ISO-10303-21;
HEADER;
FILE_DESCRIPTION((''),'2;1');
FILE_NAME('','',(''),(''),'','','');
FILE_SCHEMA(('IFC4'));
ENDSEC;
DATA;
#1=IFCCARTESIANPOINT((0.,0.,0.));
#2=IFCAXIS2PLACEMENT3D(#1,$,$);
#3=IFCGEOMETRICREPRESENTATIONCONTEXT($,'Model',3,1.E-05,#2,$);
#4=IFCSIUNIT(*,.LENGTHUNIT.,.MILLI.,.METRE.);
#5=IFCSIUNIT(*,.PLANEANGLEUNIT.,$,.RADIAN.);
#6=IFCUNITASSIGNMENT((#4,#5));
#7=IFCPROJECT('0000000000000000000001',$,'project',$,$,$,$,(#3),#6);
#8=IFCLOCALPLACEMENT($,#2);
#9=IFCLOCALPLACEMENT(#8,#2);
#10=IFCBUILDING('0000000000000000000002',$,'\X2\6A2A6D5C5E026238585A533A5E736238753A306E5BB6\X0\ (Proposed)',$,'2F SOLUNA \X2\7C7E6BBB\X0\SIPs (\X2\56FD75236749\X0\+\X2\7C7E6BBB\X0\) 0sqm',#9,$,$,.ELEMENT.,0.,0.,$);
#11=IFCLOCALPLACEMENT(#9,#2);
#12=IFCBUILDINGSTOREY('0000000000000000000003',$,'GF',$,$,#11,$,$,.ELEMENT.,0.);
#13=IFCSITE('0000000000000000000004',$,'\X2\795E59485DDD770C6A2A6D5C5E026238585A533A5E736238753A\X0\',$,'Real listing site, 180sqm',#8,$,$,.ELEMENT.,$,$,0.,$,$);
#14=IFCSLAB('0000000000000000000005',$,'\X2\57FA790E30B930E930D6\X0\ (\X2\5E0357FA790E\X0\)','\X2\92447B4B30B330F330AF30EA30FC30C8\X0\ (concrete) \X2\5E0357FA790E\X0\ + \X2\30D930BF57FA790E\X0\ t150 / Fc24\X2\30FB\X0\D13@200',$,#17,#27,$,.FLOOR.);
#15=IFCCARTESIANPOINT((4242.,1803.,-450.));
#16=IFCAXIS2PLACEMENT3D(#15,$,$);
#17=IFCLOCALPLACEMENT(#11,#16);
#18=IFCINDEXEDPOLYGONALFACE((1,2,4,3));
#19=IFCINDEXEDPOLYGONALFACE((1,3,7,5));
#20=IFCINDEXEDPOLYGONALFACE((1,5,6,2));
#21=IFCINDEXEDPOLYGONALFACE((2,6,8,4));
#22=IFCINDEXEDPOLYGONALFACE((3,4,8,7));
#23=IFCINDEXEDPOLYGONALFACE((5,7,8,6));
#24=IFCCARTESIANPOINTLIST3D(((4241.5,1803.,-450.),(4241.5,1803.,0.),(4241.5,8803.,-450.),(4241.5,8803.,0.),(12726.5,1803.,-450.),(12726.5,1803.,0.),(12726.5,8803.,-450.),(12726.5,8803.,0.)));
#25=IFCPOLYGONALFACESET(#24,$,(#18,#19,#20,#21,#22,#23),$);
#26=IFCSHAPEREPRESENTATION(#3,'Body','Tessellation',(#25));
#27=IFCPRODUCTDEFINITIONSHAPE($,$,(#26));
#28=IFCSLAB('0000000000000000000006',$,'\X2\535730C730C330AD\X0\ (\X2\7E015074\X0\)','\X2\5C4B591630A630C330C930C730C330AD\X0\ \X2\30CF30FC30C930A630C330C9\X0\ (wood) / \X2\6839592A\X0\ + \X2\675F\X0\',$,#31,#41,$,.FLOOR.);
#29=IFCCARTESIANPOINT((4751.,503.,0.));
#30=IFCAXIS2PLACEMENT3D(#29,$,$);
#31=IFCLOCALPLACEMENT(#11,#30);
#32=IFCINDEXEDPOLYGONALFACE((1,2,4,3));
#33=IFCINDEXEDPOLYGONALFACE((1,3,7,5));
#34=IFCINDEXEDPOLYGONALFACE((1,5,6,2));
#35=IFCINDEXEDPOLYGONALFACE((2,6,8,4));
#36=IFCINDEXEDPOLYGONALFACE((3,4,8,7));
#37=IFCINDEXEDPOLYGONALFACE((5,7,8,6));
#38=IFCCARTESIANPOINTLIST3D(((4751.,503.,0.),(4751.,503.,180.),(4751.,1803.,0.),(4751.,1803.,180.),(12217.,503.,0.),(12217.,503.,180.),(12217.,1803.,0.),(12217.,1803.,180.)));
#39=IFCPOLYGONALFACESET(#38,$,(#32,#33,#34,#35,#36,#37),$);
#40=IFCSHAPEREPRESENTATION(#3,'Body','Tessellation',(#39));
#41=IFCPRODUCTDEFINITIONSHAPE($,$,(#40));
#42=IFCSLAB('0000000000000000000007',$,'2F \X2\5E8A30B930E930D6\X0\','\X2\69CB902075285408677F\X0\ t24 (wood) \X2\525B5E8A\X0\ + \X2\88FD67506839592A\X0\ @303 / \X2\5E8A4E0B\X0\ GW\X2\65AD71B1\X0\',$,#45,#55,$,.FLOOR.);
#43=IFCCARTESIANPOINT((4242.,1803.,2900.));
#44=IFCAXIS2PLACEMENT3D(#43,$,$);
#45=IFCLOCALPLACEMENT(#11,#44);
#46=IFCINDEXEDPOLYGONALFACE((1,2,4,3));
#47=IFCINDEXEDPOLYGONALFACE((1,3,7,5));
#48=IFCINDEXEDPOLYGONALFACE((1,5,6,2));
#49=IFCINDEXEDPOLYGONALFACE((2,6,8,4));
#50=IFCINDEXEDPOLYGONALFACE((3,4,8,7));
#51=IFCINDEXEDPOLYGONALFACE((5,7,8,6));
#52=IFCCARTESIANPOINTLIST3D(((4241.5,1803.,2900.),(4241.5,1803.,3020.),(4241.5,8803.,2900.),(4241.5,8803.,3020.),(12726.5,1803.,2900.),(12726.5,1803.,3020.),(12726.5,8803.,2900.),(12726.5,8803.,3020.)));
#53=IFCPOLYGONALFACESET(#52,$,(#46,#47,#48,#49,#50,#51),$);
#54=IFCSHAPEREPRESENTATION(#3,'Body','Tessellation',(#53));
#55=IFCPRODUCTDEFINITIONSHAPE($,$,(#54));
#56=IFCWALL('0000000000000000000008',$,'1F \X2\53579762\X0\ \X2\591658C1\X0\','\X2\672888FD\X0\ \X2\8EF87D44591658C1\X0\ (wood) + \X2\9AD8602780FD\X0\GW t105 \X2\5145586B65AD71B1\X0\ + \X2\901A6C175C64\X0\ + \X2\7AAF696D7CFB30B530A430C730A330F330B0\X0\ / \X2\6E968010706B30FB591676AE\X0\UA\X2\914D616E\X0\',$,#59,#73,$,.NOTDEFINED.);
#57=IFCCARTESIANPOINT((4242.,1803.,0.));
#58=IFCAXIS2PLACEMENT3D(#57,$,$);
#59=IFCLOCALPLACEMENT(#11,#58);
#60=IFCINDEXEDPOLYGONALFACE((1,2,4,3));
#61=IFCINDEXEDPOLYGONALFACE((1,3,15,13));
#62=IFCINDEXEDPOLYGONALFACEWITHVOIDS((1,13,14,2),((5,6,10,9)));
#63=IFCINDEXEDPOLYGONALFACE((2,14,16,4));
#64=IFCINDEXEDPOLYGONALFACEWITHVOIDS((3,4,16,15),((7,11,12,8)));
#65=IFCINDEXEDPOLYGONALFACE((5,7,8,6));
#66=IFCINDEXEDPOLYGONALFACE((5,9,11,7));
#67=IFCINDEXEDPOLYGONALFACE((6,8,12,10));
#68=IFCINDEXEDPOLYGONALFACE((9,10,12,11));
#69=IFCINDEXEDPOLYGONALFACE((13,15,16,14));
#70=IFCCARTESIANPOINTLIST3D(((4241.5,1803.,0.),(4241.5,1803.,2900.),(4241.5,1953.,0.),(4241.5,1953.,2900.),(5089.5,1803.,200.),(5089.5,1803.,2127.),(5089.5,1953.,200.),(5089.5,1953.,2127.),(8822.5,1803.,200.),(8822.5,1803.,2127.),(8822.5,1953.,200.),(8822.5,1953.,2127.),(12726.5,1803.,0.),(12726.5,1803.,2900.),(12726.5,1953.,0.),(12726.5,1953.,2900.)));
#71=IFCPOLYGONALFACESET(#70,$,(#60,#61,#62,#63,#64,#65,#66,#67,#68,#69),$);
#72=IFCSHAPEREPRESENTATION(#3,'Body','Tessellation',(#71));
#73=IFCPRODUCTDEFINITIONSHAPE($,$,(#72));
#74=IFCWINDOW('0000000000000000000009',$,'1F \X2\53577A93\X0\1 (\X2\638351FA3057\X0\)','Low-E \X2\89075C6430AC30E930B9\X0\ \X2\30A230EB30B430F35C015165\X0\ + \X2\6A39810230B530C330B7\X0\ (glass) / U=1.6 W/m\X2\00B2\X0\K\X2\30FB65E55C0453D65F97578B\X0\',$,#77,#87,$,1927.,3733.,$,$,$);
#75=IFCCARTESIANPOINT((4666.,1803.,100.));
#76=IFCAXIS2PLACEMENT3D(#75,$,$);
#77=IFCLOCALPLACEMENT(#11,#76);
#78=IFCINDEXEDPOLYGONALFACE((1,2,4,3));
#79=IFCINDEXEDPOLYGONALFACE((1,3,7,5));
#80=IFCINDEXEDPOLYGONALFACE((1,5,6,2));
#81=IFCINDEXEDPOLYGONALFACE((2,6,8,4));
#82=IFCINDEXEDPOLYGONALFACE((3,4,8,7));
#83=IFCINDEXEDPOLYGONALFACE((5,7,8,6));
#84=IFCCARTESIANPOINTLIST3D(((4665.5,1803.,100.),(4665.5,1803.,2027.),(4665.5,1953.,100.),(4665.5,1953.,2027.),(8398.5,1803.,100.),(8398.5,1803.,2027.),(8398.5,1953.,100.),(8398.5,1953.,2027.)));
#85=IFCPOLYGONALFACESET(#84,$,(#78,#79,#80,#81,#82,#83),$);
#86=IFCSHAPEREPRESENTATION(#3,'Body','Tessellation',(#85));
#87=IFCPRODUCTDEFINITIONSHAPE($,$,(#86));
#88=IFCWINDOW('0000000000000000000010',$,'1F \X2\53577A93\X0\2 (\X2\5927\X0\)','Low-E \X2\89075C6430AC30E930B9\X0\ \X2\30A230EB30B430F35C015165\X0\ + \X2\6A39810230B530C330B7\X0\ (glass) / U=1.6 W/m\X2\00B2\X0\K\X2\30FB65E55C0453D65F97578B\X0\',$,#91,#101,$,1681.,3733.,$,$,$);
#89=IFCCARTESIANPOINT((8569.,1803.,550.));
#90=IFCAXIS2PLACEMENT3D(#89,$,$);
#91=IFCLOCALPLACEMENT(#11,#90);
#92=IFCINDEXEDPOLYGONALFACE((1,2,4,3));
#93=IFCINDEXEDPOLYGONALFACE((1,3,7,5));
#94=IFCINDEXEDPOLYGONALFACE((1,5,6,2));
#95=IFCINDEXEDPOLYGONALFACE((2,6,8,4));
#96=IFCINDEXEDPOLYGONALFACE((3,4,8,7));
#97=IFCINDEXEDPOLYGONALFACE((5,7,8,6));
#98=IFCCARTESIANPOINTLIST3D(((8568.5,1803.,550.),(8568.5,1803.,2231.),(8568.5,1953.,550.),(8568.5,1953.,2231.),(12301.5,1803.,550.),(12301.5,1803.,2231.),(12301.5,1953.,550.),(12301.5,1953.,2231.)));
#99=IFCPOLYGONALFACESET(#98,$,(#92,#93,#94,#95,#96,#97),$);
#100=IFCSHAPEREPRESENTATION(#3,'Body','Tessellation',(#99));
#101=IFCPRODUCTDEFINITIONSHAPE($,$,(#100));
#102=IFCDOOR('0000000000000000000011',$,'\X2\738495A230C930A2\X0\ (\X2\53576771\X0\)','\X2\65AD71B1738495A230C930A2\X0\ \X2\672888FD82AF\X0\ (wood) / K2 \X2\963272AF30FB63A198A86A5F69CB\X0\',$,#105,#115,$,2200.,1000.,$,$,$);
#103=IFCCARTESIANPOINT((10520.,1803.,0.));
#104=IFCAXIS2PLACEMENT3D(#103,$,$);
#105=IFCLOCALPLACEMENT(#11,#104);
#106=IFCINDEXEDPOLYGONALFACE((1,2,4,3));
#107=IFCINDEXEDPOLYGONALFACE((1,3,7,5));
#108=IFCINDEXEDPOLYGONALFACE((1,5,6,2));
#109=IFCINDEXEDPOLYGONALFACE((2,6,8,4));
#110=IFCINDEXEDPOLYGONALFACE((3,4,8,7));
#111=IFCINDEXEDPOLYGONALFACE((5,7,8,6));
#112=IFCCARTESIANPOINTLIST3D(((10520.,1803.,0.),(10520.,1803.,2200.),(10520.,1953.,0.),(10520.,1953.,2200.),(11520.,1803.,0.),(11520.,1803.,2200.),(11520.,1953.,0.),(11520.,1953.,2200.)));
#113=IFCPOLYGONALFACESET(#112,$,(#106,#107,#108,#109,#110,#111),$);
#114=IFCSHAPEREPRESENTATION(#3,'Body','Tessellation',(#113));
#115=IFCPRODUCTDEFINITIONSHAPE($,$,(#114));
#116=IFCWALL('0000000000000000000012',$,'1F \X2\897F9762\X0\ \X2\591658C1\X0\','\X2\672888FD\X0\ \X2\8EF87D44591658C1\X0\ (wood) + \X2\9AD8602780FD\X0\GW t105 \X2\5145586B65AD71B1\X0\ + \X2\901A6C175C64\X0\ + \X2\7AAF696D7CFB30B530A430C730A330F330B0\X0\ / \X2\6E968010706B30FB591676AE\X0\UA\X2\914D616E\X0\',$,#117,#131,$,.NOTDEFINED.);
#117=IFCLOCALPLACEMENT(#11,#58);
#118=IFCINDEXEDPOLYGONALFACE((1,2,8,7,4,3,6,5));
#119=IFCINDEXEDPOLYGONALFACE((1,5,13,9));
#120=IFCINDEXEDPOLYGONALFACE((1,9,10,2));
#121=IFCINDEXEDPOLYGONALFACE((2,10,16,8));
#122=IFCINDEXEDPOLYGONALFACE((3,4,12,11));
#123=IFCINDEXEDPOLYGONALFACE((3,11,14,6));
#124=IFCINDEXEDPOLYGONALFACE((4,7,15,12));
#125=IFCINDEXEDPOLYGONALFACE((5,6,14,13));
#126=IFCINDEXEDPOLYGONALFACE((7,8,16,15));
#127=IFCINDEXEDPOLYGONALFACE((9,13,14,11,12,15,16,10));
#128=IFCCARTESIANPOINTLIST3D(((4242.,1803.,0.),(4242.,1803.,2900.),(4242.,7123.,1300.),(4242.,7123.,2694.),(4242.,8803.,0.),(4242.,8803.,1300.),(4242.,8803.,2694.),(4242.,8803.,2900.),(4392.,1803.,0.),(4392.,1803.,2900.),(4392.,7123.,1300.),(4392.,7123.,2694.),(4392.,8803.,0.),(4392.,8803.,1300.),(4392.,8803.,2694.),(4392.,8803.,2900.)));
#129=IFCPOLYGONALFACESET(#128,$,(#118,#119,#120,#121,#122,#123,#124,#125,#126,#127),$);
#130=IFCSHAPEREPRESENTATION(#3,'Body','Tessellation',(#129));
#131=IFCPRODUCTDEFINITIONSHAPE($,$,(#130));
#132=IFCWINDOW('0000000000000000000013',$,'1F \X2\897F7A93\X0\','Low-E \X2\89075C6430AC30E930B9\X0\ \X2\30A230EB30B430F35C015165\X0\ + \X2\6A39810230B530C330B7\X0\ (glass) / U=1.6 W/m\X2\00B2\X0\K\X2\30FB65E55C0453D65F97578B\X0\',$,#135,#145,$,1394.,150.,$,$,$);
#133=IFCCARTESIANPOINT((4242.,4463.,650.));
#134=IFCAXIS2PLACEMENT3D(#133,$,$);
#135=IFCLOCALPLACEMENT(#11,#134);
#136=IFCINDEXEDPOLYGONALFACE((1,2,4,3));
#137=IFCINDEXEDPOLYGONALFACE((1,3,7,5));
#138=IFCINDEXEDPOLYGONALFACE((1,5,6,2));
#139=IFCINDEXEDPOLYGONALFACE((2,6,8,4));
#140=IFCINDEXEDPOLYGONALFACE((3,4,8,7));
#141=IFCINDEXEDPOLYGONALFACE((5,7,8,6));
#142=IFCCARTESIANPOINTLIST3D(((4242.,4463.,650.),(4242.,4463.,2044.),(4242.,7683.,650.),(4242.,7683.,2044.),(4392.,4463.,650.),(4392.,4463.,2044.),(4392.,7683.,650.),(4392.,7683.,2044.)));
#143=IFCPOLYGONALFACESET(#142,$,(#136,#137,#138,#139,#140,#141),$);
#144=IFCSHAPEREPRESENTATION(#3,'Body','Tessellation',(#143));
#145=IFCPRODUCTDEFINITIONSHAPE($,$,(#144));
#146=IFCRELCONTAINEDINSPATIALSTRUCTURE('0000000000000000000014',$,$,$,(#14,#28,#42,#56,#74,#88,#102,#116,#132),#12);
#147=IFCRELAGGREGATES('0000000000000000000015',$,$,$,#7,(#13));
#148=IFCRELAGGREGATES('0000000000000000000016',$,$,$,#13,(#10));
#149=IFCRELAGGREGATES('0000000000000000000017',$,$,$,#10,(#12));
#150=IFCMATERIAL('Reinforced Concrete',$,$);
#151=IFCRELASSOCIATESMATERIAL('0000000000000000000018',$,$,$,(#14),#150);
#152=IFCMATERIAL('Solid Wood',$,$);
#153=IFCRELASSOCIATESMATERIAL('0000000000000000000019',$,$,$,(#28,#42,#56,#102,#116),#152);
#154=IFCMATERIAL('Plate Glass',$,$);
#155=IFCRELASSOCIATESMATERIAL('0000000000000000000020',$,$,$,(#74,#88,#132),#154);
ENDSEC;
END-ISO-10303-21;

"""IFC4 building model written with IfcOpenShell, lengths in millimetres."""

from ifc_helpers import new_model, si_unit, frame, frame_2d, origin, place, context, project, spatial, rectangle, extrude, material, element, fill, save


model = new_model("IFC4")

# Units and contexts
model_context = context("Model", 3, precision=1e-05, world=origin())
ifc_project = project(units=[si_unit("LENGTHUNIT", "METRE", prefix="MILLI"), si_unit("PLANEANGLEUNIT", "RADIAN")], contexts=[model_context])

# Site, building, storey
site_placement = place(None, origin())
site = spatial("IfcSite", under=ifc_project, at=site_placement, Name="神奈川県横浜市戸塚区平戸町", ObjectType="Real listing site, 180sqm", CompositionType="ELEMENT", RefElevation=0.0)
building_placement = place(site_placement, origin())
building = spatial("IfcBuilding", under=site, at=building_placement, Name="横浜市戸塚区平戸町の家 (Proposed)", ObjectType="2F SOLUNA 籾殻SIPs (国産杉+籾殻) 0sqm", CompositionType="ELEMENT", ElevationOfRefHeight=0.0, ElevationOfTerrain=0.0)
storey_placement = place(building_placement, origin())
storey = spatial("IfcBuildingStorey", under=building, at=storey_placement, Name="GF", CompositionType="ELEMENT", Elevation=0.0)

# Slabs
ifc_material_1 = material(Name="Reinforced Concrete")
slab_1_placement = place(storey_placement, frame((4242.0, 1803.0, -450.0)))
element("IfcSlab", 1, at=slab_1_placement, inside=storey, material=ifc_material_1, Name="基礎スラブ (布基礎)", Description="鉄筋コンクリート (concrete) 布基礎 + ベタ基礎 t150 / Fc24・D13@200", PredefinedType="FLOOR", context=model_context, shape_type="SweptSolid", body=[
    extrude(rectangle(XDim=8485.0, YDim=7000.0, at=frame_2d((4242.0, 3500.0))), frame((4242.0, 1803.0, -450.0)), (0.0, 0.0, 1.0), 450.0),
])
ifc_material_2 = material(Name="Solid Wood")
slab_2_placement = place(storey_placement, frame((4751.0, 503.0, 0.0)))
element("IfcSlab", 2, at=slab_2_placement, inside=storey, material=ifc_material_2, Name="南デッキ (縁側)", Description="屋外ウッドデッキ ハードウッド (wood) / 根太 + 束", PredefinedType="FLOOR", context=model_context, shape_type="SweptSolid", body=[
    extrude(rectangle(XDim=7466.0, YDim=1300.0, at=frame_2d((3733.0, 650.0))), frame((4751.0, 503.0, 0.0)), (0.0, 0.0, 1.0), 180.0),
])
slab_3_placement = place(storey_placement, frame((4242.0, 1803.0, 2900.0)))
element("IfcSlab", 3, at=slab_3_placement, inside=storey, material=ifc_material_2, Name="2F 床スラブ", Description="構造用合板 t24 (wood) 剛床 + 製材根太 @303 / 床下 GW断熱", PredefinedType="FLOOR", context=model_context, shape_type="SweptSolid", body=[
    extrude(rectangle(XDim=8485.0, YDim=7000.0, at=frame_2d((4242.0, 3500.0))), frame((4242.0, 1803.0, 2900.0)), (0.0, 0.0, 1.0), 120.0),
])

# Wall, openings, windows, door
wall_1_placement = place(storey_placement, frame((4242.0, 1803.0, 0.0)))
wall_1 = element("IfcWall", 4, at=wall_1_placement, inside=storey, material=ifc_material_2, Name="1F 南面 外壁", Description="木製 軸組外壁 (wood) + 高性能GW t105 充填断熱 + 通気層 + 窯業系サイディング / 準耐火・外皮UA配慮", PredefinedType="NOTDEFINED", context=model_context, shape_type="SweptSolid", body=[
    extrude(rectangle(XDim=8485.0, YDim=150.0, at=frame_2d((4242.0, 75.0))), frame((4242.0, 1803.0, 0.0)), (0.0, 0.0, 1.0), 2900.0),
])
opening_1_placement = place(storey_placement, frame((4666.0, 1803.0, 100.0)))
opening_1 = element("IfcOpeningElement", 5, at=opening_1_placement, cuts=wall_1, PredefinedType="NOTDEFINED", context=model_context, shape_type="SweptSolid", body=[
    extrude(rectangle(XDim=3733.0, YDim=150.0, at=frame_2d((1866.0, 75.0))), frame((4666.0, 1803.0, 100.0)), (0.0, 0.0, 1.0), 1927.0),
])
opening_2_placement = place(storey_placement, frame((8569.0, 1803.0, 550.0)))
opening_2 = element("IfcOpeningElement", 6, at=opening_2_placement, cuts=wall_1, PredefinedType="NOTDEFINED", context=model_context, shape_type="SweptSolid", body=[
    extrude(rectangle(XDim=3733.0, YDim=150.0, at=frame_2d((1866.0, 75.0))), frame((8569.0, 1803.0, 550.0)), (0.0, 0.0, 1.0), 1681.0),
])
opening_3_placement = place(storey_placement, frame((10520.0, 1803.0, 0.0)))
opening_3 = element("IfcOpeningElement", 7, at=opening_3_placement, cuts=wall_1, PredefinedType="NOTDEFINED", context=model_context, shape_type="SweptSolid", body=[
    extrude(rectangle(XDim=1000.0, YDim=150.0, at=frame_2d((500.0, 75.0))), frame((10520.0, 1803.0, 0.0)), (0.0, 0.0, 1.0), 2200.0),
])
ifc_material_3 = material(Name="Plate Glass")
window_1_placement = place(storey_placement, frame((4666.0, 1803.0, 100.0)))
window_1 = element("IfcWindow", 8, at=window_1_placement, inside=storey, material=ifc_material_3, Name="1F 南窓1 (掃出し)", Description="Low-E 複層ガラス アルゴン封入 + 樹脂サッシ (glass) / U=1.6 W/m²K・日射取得型", OverallHeight=1927.0, OverallWidth=3733.0, context=model_context, shape_type="SweptSolid", body=[
    extrude(rectangle(XDim=3733.0, YDim=150.0, at=frame_2d((1866.0, 75.0))), frame((4666.0, 1803.0, 100.0)), (0.0, 0.0, 1.0), 1927.0),
])
fill(opening_1, window_1)
window_2_placement = place(storey_placement, frame((8569.0, 1803.0, 550.0)))
window_2 = element("IfcWindow", 9, at=window_2_placement, inside=storey, material=ifc_material_3, Name="1F 南窓2 (大)", Description="Low-E 複層ガラス アルゴン封入 + 樹脂サッシ (glass) / U=1.6 W/m²K・日射取得型", OverallHeight=1681.0, OverallWidth=3733.0, context=model_context, shape_type="SweptSolid", body=[
    extrude(rectangle(XDim=3733.0, YDim=150.0, at=frame_2d((1866.0, 75.0))), frame((8569.0, 1803.0, 550.0)), (0.0, 0.0, 1.0), 1681.0),
])
fill(opening_2, window_2)
door_placement = place(storey_placement, frame((10520.0, 1803.0, 0.0)))
door = element("IfcDoor", 10, at=door_placement, inside=storey, material=ifc_material_2, Name="玄関ドア (南東)", Description="断熱玄関ドア 木製芯 (wood) / K2 防犯・採風機構", OverallHeight=2200.0, OverallWidth=1000.0, context=model_context, shape_type="SweptSolid", body=[
    extrude(rectangle(XDim=1000.0, YDim=150.0, at=frame_2d((500.0, 75.0))), frame((10520.0, 1803.0, 0.0)), (0.0, 0.0, 1.0), 2200.0),
])
fill(opening_3, door)

# Wall, opening, window
wall_2_placement = place(storey_placement, frame((4242.0, 1803.0, 0.0)))
wall_2 = element("IfcWall", 11, at=wall_2_placement, inside=storey, material=ifc_material_2, Name="1F 西面 外壁", Description="木製 軸組外壁 (wood) + 高性能GW t105 充填断熱 + 通気層 + 窯業系サイディング / 準耐火・外皮UA配慮", PredefinedType="NOTDEFINED", context=model_context, shape_type="SweptSolid", body=[
    extrude(rectangle(XDim=150.0, YDim=7000.0, at=frame_2d((75.0, 3500.0))), frame((4242.0, 1803.0, 0.0)), (0.0, 0.0, 1.0), 2900.0),
])
opening_4_placement = place(storey_placement, frame((4242.0, 4463.0, 650.0)))
opening_4 = element("IfcOpeningElement", 12, at=opening_4_placement, cuts=wall_2, PredefinedType="NOTDEFINED", context=model_context, shape_type="SweptSolid", body=[
    extrude(rectangle(XDim=150.0, YDim=3220.0, at=frame_2d((75.0, 1610.0))), frame((4242.0, 4463.0, 650.0)), (0.0, 0.0, 1.0), 1394.0),
])
window_3_placement = place(storey_placement, frame((4242.0, 4463.0, 650.0)))
window_3 = element("IfcWindow", 13, at=window_3_placement, inside=storey, material=ifc_material_3, Name="1F 西窓", Description="Low-E 複層ガラス アルゴン封入 + 樹脂サッシ (glass) / U=1.6 W/m²K・日射取得型", OverallHeight=1394.0, OverallWidth=150.0, context=model_context, shape_type="SweptSolid", body=[
    extrude(rectangle(XDim=150.0, YDim=3220.0, at=frame_2d((75.0, 1610.0))), frame((4242.0, 4463.0, 650.0)), (0.0, 0.0, 1.0), 1394.0),
])
fill(opening_4, window_3)

save(model, "model.ifc")
